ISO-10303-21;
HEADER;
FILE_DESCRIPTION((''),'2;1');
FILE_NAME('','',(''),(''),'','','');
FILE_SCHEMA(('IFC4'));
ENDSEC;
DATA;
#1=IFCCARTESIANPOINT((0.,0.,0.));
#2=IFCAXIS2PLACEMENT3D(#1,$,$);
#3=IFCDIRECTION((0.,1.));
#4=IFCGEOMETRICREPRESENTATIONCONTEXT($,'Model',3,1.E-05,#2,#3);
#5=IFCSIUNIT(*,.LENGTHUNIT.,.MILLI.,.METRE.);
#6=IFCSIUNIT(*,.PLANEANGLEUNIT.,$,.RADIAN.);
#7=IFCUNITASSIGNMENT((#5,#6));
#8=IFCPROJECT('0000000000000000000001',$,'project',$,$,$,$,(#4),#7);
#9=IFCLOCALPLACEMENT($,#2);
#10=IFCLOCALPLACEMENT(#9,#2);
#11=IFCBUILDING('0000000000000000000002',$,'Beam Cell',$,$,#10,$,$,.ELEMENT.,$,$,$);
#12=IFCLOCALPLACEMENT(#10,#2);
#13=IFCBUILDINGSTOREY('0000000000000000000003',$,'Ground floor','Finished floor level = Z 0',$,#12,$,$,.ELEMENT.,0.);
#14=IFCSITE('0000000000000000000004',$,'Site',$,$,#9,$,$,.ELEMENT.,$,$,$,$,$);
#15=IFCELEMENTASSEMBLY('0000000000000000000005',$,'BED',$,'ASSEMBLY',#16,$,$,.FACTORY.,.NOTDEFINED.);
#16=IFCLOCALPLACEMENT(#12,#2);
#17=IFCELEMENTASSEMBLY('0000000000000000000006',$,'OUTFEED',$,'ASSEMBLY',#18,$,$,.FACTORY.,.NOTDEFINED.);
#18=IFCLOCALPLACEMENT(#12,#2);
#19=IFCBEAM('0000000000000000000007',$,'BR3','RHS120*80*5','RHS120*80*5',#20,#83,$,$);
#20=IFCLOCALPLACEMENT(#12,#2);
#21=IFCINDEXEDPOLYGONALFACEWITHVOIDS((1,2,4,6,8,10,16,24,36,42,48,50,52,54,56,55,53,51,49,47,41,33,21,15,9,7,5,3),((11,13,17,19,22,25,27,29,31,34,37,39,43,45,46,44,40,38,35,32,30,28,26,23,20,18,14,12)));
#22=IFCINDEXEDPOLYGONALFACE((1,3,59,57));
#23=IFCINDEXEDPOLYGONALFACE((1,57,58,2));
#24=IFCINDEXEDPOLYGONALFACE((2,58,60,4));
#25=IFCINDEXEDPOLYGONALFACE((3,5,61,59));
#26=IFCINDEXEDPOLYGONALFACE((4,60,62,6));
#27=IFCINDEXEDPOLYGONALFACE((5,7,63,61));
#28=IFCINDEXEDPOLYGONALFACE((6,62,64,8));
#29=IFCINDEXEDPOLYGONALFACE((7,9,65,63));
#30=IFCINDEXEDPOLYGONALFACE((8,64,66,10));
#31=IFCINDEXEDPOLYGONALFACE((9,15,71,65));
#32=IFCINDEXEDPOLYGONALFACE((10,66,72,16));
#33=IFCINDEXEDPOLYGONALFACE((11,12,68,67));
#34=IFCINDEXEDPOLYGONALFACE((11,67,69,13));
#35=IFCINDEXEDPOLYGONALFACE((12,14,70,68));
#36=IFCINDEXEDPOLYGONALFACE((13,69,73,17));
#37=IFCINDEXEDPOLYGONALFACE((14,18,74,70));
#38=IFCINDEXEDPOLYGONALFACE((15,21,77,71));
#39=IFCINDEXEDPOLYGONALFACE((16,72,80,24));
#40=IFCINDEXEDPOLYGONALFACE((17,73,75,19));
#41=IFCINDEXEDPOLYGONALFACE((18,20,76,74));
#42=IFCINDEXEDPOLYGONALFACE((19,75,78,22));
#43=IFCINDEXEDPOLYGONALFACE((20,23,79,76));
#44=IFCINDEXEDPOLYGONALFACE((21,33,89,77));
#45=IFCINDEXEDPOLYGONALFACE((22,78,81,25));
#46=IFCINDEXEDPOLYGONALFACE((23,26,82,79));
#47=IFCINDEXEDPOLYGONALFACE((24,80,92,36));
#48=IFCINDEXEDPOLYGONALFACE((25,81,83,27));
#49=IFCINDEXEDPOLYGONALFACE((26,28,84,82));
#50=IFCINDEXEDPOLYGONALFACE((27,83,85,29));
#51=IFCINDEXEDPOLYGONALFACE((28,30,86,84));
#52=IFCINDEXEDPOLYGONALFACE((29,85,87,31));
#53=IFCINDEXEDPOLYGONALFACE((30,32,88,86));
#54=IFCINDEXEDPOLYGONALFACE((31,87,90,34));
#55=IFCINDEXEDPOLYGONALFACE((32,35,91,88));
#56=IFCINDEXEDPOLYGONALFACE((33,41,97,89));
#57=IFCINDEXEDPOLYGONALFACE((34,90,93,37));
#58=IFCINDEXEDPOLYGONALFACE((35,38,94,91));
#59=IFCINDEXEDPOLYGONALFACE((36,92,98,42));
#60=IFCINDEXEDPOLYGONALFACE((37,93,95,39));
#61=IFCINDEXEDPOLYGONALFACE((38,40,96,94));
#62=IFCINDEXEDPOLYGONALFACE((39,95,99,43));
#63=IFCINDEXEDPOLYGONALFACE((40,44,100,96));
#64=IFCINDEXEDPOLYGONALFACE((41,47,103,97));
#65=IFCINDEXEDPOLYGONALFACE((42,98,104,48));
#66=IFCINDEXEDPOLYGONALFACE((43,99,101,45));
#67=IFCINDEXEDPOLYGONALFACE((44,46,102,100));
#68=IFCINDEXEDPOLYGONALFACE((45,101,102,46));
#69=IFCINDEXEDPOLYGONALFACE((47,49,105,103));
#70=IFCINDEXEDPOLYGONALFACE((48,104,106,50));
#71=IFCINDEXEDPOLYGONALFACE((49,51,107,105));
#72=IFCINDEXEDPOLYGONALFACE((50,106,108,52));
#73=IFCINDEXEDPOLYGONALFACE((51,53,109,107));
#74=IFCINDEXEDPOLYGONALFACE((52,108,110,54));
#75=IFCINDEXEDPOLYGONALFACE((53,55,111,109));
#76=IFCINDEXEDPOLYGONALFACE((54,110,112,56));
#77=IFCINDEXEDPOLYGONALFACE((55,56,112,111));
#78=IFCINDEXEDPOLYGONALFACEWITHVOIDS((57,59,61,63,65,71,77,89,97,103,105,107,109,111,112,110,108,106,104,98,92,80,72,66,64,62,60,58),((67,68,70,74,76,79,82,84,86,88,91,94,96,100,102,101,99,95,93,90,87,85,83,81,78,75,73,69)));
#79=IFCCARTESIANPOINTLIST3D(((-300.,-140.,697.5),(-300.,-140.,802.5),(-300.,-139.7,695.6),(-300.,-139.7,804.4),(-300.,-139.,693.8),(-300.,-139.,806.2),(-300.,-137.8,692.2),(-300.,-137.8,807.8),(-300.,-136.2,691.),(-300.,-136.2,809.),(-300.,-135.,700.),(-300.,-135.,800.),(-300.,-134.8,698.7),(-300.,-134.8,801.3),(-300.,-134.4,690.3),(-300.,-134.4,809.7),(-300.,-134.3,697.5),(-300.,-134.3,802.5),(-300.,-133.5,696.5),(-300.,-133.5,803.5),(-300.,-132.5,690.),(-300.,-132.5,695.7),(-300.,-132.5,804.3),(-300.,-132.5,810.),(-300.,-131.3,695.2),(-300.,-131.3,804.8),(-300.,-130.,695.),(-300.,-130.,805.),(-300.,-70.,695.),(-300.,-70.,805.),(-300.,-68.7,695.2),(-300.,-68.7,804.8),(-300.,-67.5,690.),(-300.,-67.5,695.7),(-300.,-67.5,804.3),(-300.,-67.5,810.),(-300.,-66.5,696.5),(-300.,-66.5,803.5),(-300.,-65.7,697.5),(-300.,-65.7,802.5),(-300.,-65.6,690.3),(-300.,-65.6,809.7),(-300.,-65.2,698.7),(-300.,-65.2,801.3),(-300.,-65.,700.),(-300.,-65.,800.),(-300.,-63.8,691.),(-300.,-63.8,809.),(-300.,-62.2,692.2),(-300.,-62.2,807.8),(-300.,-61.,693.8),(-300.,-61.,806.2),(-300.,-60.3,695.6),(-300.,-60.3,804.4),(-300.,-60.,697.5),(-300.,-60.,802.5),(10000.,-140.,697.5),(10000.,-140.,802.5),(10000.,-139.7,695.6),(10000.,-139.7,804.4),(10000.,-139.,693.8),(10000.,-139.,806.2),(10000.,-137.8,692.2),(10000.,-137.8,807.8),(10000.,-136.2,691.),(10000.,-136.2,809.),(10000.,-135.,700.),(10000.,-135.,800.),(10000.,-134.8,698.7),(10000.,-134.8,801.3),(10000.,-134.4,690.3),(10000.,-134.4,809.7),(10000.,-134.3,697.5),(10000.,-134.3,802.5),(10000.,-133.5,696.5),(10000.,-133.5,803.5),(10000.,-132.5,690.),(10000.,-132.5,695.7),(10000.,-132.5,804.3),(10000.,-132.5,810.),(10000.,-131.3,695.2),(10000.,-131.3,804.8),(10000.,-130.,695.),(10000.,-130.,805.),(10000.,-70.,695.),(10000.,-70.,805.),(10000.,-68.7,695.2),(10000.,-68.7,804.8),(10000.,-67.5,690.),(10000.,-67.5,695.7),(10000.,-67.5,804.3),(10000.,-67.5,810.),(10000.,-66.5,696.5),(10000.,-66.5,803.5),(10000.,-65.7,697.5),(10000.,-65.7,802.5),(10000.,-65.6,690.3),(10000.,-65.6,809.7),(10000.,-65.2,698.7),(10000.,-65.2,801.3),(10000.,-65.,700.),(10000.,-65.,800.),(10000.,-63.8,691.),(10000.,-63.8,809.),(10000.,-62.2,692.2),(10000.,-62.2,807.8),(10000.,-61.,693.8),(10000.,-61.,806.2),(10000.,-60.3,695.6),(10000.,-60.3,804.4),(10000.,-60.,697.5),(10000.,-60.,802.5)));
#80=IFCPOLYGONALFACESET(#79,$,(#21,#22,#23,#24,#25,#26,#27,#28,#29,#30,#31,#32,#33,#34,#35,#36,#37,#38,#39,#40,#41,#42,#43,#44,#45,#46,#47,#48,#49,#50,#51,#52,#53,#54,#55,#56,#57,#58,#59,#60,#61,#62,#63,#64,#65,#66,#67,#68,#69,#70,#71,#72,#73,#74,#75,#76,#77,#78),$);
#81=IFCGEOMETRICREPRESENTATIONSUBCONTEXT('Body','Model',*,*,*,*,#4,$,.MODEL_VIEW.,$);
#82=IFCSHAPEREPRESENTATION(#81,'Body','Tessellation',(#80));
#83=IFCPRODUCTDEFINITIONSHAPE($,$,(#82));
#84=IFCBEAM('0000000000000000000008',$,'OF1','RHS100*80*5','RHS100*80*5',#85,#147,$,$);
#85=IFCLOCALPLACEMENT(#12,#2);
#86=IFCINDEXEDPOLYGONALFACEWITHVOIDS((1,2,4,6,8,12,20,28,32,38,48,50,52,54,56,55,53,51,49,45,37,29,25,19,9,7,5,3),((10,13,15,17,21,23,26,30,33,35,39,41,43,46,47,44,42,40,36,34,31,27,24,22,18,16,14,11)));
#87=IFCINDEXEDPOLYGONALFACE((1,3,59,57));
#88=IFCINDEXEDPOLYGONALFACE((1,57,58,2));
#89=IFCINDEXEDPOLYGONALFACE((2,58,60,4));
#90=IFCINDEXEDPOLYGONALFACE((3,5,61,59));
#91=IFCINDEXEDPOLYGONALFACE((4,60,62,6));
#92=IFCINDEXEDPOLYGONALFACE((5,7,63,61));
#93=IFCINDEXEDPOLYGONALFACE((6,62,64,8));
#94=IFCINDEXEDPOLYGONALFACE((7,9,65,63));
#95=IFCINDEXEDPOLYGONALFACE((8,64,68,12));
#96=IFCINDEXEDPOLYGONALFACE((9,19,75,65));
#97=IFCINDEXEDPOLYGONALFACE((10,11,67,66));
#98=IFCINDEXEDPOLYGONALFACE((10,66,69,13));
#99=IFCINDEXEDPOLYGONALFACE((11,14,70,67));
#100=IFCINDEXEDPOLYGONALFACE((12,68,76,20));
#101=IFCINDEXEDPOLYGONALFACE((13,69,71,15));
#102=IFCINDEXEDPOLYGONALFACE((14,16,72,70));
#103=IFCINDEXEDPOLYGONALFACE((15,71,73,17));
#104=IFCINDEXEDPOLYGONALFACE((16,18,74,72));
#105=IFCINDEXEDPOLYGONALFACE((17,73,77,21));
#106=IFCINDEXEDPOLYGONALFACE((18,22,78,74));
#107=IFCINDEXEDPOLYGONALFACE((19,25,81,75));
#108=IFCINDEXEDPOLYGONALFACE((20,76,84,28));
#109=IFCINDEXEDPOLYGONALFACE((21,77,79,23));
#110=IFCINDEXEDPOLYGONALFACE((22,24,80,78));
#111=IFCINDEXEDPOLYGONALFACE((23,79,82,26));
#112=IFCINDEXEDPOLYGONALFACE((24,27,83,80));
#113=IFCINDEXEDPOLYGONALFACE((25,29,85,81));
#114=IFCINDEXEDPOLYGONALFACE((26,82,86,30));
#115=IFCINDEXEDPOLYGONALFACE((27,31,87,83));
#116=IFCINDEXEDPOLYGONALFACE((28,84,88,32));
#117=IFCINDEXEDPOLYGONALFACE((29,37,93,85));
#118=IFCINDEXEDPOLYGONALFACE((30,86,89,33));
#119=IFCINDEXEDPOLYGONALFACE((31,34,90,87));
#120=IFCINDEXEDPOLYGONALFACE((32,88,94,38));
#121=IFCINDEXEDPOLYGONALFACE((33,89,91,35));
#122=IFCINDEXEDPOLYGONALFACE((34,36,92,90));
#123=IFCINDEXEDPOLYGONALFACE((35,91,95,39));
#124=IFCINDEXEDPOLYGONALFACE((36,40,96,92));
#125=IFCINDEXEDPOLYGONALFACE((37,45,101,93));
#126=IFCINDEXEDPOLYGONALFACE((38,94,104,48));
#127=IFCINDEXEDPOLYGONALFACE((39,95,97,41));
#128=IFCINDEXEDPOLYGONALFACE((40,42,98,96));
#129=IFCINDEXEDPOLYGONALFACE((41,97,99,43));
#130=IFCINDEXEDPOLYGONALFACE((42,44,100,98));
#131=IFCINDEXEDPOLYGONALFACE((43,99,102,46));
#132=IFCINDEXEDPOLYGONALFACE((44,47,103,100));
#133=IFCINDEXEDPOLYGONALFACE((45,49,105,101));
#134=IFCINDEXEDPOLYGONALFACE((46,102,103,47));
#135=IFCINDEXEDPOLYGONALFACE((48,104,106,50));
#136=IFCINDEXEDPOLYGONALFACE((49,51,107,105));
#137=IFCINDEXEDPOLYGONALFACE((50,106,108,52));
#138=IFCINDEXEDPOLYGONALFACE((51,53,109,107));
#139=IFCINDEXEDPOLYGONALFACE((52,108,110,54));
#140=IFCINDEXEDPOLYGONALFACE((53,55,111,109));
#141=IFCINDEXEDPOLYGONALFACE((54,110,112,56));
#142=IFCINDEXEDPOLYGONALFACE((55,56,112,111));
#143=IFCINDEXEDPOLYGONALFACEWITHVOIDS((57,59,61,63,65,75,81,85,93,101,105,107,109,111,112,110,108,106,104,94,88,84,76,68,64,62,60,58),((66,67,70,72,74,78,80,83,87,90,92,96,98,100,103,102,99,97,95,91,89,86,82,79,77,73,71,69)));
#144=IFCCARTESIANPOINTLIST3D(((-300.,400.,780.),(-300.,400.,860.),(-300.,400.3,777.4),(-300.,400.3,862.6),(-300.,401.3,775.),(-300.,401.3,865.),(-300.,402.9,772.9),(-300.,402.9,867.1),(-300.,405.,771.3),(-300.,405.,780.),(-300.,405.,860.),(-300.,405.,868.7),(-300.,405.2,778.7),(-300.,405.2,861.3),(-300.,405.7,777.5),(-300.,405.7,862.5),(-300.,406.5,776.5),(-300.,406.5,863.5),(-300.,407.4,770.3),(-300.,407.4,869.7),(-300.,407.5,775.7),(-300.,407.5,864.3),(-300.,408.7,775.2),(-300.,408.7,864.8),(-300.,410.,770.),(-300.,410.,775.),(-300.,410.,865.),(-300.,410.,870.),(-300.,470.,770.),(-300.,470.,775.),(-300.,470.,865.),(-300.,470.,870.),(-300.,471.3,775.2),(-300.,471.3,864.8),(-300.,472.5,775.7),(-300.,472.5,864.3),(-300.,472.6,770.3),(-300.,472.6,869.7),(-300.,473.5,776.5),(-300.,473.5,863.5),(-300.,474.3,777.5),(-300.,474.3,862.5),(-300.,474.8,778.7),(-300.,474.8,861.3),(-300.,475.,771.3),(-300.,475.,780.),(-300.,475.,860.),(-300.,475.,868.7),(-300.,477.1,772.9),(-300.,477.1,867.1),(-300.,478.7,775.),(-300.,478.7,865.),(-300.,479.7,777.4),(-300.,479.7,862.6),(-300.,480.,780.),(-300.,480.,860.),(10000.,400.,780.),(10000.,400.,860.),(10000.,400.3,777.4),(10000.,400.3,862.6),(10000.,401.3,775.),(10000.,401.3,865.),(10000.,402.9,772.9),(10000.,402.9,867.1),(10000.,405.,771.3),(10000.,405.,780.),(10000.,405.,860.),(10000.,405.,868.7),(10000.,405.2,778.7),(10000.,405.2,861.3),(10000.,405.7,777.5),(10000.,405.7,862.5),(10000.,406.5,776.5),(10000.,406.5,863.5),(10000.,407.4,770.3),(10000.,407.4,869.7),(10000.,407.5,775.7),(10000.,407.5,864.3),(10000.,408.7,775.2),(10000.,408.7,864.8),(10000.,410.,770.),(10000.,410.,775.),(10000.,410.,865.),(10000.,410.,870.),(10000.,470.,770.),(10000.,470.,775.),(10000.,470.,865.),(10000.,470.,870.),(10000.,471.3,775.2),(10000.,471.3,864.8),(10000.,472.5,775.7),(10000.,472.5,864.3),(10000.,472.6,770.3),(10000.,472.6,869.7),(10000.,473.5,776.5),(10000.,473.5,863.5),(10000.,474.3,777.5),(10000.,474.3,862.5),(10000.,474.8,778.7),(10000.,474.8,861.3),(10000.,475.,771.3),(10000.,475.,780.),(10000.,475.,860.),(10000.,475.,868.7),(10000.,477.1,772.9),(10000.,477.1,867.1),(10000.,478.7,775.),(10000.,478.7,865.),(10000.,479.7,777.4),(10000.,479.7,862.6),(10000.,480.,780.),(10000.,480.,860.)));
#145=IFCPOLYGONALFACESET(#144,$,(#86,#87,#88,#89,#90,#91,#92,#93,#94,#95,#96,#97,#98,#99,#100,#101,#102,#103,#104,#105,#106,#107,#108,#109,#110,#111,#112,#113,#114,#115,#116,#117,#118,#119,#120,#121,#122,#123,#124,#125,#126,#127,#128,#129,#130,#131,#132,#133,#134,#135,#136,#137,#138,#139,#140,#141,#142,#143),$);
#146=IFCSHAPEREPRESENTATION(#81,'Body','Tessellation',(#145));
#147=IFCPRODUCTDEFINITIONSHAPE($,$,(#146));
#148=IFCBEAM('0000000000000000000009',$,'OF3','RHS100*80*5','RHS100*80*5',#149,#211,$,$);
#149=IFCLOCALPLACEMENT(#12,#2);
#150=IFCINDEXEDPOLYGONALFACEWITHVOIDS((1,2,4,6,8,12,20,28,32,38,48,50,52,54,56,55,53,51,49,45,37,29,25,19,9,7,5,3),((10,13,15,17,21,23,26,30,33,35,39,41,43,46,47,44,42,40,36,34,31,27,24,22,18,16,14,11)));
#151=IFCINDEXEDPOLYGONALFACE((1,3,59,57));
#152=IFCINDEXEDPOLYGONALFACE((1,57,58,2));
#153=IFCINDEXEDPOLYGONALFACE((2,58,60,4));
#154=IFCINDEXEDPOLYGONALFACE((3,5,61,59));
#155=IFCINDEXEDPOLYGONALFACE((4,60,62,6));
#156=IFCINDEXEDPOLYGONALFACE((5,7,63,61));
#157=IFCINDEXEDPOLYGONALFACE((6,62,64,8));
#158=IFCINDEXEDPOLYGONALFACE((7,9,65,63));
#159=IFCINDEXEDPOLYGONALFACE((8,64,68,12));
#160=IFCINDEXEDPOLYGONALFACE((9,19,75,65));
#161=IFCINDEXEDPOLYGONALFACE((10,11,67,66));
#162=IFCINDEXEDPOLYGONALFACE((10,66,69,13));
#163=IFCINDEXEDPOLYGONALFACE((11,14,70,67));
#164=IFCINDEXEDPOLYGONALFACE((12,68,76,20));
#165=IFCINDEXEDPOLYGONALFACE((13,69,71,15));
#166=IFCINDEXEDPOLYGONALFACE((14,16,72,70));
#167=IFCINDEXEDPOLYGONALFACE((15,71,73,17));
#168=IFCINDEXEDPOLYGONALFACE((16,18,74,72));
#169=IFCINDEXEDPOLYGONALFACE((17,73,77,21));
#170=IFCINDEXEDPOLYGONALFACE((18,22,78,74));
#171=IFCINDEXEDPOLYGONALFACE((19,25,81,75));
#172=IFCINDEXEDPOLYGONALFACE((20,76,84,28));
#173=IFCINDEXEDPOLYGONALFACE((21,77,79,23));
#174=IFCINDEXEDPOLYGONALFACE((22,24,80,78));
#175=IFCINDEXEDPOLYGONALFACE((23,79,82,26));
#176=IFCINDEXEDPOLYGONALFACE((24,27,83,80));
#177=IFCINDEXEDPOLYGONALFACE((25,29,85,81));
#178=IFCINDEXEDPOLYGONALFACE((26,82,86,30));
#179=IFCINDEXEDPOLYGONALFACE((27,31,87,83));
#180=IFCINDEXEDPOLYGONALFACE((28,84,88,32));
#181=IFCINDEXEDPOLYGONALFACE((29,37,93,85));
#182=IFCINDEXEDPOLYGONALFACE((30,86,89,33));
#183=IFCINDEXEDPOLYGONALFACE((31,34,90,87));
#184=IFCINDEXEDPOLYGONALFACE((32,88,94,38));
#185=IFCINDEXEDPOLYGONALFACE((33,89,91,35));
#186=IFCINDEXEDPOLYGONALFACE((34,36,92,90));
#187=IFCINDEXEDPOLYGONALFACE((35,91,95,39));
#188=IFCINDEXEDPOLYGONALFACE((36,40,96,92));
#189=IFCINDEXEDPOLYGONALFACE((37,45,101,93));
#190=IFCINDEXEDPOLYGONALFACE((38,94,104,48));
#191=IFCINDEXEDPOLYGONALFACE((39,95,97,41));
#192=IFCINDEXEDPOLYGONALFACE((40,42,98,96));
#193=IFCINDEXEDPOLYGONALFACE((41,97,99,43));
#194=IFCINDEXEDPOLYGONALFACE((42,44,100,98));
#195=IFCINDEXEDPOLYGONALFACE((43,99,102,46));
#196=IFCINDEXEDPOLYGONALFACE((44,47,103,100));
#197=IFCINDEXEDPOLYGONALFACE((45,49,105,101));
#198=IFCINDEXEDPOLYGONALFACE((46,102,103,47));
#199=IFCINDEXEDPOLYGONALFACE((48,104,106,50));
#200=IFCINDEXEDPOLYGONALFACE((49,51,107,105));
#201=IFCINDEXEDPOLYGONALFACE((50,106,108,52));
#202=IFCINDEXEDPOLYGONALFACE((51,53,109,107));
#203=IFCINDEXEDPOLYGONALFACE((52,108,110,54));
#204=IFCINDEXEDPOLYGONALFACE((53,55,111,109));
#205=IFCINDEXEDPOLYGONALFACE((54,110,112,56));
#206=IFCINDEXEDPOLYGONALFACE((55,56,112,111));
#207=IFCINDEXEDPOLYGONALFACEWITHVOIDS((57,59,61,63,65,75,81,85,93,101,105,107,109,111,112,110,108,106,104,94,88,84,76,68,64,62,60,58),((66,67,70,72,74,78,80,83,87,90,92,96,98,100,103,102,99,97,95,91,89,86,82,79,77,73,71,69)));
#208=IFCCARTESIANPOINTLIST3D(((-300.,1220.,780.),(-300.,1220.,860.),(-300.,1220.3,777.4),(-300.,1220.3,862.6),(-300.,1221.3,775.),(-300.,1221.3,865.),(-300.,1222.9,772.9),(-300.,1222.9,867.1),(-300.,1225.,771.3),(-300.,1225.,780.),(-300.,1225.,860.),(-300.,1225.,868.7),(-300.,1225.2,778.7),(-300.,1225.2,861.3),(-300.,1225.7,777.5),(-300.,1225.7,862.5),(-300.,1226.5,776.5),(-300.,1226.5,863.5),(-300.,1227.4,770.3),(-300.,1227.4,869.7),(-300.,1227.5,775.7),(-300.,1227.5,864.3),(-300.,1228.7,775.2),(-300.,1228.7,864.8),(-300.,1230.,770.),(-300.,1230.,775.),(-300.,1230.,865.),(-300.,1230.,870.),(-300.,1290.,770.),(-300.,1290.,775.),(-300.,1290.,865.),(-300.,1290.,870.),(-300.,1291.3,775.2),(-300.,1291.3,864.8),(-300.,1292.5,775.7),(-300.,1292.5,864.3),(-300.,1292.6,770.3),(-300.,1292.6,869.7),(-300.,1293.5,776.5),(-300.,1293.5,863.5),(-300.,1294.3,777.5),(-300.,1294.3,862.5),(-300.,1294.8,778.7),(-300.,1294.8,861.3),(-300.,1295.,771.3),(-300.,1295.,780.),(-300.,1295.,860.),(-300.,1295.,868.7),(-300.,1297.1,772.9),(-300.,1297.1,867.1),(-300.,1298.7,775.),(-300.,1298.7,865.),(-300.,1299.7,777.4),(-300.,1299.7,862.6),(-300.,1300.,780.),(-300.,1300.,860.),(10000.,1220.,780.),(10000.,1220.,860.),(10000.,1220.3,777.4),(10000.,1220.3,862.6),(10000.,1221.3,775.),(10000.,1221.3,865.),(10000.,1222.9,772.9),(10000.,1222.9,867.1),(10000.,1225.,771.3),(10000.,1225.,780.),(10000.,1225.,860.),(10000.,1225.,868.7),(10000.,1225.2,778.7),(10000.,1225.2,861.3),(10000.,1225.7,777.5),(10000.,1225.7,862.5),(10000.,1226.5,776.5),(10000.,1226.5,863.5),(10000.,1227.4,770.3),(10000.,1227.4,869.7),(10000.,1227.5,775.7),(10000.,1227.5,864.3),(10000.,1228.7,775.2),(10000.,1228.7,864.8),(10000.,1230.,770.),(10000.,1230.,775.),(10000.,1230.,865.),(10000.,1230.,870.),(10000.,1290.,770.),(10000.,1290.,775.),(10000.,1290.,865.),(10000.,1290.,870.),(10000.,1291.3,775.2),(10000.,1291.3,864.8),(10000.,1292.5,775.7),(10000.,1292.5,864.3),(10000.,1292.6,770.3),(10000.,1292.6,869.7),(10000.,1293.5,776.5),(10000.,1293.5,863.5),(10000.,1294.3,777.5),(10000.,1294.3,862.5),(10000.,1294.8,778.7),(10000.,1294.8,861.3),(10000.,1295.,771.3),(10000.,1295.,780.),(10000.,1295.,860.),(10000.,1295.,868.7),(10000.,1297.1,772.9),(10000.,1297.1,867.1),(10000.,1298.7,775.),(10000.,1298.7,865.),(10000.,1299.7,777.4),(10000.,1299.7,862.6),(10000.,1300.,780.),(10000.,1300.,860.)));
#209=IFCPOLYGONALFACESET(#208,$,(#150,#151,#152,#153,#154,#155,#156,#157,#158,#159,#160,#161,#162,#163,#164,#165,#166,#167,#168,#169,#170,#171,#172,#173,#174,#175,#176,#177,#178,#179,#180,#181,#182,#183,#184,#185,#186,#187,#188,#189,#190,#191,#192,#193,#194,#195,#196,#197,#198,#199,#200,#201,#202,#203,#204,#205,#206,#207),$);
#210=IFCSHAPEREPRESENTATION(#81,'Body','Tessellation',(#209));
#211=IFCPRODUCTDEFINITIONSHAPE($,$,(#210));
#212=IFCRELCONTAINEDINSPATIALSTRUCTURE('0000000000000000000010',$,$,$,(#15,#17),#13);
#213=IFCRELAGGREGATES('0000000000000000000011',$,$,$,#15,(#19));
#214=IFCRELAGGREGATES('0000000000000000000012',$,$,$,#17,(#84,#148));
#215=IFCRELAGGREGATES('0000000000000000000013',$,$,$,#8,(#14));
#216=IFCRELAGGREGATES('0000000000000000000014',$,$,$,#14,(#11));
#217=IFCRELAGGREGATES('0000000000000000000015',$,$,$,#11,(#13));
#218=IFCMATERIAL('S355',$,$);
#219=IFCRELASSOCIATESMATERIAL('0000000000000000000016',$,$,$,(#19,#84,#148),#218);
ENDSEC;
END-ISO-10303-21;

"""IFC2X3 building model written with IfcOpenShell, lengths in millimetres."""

from ifc_helpers import new_model, si_unit, direction, frame, origin, origin_2d, place, context, subcontext, project, spatial, hollow_rectangle, extrude, material, element, aggregate, save


model = new_model("IFC2X3")

# Units and contexts
model_context = context("Model", 3, precision=1e-05, world=origin(), true_north=direction((0.0, 1.0)))
body_context = subcontext(model_context, "Body", "Model", "MODEL_VIEW")
ifc_project = project(units=[si_unit("LENGTHUNIT", "METRE", prefix="MILLI"), si_unit("PLANEANGLEUNIT", "RADIAN")], contexts=[model_context])

# Site, building, storey
site_placement = place(None, origin())
site = spatial("IfcSite", under=ifc_project, at=site_placement, Name="Site", CompositionType="ELEMENT")
building_placement = place(site_placement, origin())
building = spatial("IfcBuilding", under=site, at=building_placement, Name="Beam Cell", CompositionType="ELEMENT")
storey_placement = place(building_placement, origin())
storey = spatial("IfcBuildingStorey", under=building, at=storey_placement, Name="Ground floor", Description="Finished floor level = Z 0", CompositionType="ELEMENT", Elevation=0.0)

# Shared definitions
ifc_material = material(Name="S355")

# Element assemblies
assembly_1_placement = place(storey_placement, origin())
assembly_1 = element("IfcElementAssembly", 1, at=assembly_1_placement, inside=storey, Name="BED", ObjectType="ASSEMBLY", AssemblyPlace="FACTORY", PredefinedType="NOTDEFINED")
assembly_2_placement = place(storey_placement, origin())
assembly_2 = element("IfcElementAssembly", 2, at=assembly_2_placement, inside=storey, Name="OUTFEED", ObjectType="ASSEMBLY", AssemblyPlace="FACTORY", PredefinedType="NOTDEFINED")

# Beams
beam_1_placement = place(storey_placement, frame((-300.0, -100.0, 750.0), z_axis=(1.0, 0.0, 0.0), x_axis=(0.0, 1.0, 0.0)))
beam_1 = element("IfcBeam", 3, at=beam_1_placement, material=ifc_material, Name="BR3", Description="RHS120*80*5", ObjectType="RHS120*80*5", context=body_context, shape_type="SweptSolid", body=[
    extrude(hollow_rectangle(XDim=80.0, YDim=120.0, WallThickness=5.0, InnerFilletRadius=5.0, OuterFilletRadius=7.5, at=origin_2d()), origin(), (0.0, 0.0, 1.0), 10300.0),
])
aggregate(assembly_1, [beam_1])
beam_2_placement = place(storey_placement, frame((-300.0, 440.0, 820.0), z_axis=(1.0, 0.0, 0.0), x_axis=(0.0, 1.0, 0.0)))
beam_2 = element("IfcBeam", 4, at=beam_2_placement, material=ifc_material, Name="OF1", Description="RHS100*80*5", ObjectType="RHS100*80*5", context=body_context, shape_type="SweptSolid", body=[
    extrude(hollow_rectangle(XDim=80.0, YDim=100.0, WallThickness=5.0, InnerFilletRadius=5.0, OuterFilletRadius=10.0, at=origin_2d()), origin(), (0.0, 0.0, 1.0), 10300.0),
])
beam_3_placement = place(storey_placement, frame((-300.0, 1260.0, 820.0), z_axis=(1.0, 0.0, 0.0), x_axis=(0.0, 1.0, 0.0)))
beam_3 = element("IfcBeam", 5, at=beam_3_placement, material=ifc_material, Name="OF3", Description="RHS100*80*5", ObjectType="RHS100*80*5", context=body_context, shape_type="SweptSolid", body=[
    extrude(hollow_rectangle(XDim=80.0, YDim=100.0, WallThickness=5.0, InnerFilletRadius=5.0, OuterFilletRadius=10.0, at=origin_2d()), origin(), (0.0, 0.0, 1.0), 10300.0),
])
aggregate(assembly_2, [beam_2, beam_3])

save(model, "model.ifc")
